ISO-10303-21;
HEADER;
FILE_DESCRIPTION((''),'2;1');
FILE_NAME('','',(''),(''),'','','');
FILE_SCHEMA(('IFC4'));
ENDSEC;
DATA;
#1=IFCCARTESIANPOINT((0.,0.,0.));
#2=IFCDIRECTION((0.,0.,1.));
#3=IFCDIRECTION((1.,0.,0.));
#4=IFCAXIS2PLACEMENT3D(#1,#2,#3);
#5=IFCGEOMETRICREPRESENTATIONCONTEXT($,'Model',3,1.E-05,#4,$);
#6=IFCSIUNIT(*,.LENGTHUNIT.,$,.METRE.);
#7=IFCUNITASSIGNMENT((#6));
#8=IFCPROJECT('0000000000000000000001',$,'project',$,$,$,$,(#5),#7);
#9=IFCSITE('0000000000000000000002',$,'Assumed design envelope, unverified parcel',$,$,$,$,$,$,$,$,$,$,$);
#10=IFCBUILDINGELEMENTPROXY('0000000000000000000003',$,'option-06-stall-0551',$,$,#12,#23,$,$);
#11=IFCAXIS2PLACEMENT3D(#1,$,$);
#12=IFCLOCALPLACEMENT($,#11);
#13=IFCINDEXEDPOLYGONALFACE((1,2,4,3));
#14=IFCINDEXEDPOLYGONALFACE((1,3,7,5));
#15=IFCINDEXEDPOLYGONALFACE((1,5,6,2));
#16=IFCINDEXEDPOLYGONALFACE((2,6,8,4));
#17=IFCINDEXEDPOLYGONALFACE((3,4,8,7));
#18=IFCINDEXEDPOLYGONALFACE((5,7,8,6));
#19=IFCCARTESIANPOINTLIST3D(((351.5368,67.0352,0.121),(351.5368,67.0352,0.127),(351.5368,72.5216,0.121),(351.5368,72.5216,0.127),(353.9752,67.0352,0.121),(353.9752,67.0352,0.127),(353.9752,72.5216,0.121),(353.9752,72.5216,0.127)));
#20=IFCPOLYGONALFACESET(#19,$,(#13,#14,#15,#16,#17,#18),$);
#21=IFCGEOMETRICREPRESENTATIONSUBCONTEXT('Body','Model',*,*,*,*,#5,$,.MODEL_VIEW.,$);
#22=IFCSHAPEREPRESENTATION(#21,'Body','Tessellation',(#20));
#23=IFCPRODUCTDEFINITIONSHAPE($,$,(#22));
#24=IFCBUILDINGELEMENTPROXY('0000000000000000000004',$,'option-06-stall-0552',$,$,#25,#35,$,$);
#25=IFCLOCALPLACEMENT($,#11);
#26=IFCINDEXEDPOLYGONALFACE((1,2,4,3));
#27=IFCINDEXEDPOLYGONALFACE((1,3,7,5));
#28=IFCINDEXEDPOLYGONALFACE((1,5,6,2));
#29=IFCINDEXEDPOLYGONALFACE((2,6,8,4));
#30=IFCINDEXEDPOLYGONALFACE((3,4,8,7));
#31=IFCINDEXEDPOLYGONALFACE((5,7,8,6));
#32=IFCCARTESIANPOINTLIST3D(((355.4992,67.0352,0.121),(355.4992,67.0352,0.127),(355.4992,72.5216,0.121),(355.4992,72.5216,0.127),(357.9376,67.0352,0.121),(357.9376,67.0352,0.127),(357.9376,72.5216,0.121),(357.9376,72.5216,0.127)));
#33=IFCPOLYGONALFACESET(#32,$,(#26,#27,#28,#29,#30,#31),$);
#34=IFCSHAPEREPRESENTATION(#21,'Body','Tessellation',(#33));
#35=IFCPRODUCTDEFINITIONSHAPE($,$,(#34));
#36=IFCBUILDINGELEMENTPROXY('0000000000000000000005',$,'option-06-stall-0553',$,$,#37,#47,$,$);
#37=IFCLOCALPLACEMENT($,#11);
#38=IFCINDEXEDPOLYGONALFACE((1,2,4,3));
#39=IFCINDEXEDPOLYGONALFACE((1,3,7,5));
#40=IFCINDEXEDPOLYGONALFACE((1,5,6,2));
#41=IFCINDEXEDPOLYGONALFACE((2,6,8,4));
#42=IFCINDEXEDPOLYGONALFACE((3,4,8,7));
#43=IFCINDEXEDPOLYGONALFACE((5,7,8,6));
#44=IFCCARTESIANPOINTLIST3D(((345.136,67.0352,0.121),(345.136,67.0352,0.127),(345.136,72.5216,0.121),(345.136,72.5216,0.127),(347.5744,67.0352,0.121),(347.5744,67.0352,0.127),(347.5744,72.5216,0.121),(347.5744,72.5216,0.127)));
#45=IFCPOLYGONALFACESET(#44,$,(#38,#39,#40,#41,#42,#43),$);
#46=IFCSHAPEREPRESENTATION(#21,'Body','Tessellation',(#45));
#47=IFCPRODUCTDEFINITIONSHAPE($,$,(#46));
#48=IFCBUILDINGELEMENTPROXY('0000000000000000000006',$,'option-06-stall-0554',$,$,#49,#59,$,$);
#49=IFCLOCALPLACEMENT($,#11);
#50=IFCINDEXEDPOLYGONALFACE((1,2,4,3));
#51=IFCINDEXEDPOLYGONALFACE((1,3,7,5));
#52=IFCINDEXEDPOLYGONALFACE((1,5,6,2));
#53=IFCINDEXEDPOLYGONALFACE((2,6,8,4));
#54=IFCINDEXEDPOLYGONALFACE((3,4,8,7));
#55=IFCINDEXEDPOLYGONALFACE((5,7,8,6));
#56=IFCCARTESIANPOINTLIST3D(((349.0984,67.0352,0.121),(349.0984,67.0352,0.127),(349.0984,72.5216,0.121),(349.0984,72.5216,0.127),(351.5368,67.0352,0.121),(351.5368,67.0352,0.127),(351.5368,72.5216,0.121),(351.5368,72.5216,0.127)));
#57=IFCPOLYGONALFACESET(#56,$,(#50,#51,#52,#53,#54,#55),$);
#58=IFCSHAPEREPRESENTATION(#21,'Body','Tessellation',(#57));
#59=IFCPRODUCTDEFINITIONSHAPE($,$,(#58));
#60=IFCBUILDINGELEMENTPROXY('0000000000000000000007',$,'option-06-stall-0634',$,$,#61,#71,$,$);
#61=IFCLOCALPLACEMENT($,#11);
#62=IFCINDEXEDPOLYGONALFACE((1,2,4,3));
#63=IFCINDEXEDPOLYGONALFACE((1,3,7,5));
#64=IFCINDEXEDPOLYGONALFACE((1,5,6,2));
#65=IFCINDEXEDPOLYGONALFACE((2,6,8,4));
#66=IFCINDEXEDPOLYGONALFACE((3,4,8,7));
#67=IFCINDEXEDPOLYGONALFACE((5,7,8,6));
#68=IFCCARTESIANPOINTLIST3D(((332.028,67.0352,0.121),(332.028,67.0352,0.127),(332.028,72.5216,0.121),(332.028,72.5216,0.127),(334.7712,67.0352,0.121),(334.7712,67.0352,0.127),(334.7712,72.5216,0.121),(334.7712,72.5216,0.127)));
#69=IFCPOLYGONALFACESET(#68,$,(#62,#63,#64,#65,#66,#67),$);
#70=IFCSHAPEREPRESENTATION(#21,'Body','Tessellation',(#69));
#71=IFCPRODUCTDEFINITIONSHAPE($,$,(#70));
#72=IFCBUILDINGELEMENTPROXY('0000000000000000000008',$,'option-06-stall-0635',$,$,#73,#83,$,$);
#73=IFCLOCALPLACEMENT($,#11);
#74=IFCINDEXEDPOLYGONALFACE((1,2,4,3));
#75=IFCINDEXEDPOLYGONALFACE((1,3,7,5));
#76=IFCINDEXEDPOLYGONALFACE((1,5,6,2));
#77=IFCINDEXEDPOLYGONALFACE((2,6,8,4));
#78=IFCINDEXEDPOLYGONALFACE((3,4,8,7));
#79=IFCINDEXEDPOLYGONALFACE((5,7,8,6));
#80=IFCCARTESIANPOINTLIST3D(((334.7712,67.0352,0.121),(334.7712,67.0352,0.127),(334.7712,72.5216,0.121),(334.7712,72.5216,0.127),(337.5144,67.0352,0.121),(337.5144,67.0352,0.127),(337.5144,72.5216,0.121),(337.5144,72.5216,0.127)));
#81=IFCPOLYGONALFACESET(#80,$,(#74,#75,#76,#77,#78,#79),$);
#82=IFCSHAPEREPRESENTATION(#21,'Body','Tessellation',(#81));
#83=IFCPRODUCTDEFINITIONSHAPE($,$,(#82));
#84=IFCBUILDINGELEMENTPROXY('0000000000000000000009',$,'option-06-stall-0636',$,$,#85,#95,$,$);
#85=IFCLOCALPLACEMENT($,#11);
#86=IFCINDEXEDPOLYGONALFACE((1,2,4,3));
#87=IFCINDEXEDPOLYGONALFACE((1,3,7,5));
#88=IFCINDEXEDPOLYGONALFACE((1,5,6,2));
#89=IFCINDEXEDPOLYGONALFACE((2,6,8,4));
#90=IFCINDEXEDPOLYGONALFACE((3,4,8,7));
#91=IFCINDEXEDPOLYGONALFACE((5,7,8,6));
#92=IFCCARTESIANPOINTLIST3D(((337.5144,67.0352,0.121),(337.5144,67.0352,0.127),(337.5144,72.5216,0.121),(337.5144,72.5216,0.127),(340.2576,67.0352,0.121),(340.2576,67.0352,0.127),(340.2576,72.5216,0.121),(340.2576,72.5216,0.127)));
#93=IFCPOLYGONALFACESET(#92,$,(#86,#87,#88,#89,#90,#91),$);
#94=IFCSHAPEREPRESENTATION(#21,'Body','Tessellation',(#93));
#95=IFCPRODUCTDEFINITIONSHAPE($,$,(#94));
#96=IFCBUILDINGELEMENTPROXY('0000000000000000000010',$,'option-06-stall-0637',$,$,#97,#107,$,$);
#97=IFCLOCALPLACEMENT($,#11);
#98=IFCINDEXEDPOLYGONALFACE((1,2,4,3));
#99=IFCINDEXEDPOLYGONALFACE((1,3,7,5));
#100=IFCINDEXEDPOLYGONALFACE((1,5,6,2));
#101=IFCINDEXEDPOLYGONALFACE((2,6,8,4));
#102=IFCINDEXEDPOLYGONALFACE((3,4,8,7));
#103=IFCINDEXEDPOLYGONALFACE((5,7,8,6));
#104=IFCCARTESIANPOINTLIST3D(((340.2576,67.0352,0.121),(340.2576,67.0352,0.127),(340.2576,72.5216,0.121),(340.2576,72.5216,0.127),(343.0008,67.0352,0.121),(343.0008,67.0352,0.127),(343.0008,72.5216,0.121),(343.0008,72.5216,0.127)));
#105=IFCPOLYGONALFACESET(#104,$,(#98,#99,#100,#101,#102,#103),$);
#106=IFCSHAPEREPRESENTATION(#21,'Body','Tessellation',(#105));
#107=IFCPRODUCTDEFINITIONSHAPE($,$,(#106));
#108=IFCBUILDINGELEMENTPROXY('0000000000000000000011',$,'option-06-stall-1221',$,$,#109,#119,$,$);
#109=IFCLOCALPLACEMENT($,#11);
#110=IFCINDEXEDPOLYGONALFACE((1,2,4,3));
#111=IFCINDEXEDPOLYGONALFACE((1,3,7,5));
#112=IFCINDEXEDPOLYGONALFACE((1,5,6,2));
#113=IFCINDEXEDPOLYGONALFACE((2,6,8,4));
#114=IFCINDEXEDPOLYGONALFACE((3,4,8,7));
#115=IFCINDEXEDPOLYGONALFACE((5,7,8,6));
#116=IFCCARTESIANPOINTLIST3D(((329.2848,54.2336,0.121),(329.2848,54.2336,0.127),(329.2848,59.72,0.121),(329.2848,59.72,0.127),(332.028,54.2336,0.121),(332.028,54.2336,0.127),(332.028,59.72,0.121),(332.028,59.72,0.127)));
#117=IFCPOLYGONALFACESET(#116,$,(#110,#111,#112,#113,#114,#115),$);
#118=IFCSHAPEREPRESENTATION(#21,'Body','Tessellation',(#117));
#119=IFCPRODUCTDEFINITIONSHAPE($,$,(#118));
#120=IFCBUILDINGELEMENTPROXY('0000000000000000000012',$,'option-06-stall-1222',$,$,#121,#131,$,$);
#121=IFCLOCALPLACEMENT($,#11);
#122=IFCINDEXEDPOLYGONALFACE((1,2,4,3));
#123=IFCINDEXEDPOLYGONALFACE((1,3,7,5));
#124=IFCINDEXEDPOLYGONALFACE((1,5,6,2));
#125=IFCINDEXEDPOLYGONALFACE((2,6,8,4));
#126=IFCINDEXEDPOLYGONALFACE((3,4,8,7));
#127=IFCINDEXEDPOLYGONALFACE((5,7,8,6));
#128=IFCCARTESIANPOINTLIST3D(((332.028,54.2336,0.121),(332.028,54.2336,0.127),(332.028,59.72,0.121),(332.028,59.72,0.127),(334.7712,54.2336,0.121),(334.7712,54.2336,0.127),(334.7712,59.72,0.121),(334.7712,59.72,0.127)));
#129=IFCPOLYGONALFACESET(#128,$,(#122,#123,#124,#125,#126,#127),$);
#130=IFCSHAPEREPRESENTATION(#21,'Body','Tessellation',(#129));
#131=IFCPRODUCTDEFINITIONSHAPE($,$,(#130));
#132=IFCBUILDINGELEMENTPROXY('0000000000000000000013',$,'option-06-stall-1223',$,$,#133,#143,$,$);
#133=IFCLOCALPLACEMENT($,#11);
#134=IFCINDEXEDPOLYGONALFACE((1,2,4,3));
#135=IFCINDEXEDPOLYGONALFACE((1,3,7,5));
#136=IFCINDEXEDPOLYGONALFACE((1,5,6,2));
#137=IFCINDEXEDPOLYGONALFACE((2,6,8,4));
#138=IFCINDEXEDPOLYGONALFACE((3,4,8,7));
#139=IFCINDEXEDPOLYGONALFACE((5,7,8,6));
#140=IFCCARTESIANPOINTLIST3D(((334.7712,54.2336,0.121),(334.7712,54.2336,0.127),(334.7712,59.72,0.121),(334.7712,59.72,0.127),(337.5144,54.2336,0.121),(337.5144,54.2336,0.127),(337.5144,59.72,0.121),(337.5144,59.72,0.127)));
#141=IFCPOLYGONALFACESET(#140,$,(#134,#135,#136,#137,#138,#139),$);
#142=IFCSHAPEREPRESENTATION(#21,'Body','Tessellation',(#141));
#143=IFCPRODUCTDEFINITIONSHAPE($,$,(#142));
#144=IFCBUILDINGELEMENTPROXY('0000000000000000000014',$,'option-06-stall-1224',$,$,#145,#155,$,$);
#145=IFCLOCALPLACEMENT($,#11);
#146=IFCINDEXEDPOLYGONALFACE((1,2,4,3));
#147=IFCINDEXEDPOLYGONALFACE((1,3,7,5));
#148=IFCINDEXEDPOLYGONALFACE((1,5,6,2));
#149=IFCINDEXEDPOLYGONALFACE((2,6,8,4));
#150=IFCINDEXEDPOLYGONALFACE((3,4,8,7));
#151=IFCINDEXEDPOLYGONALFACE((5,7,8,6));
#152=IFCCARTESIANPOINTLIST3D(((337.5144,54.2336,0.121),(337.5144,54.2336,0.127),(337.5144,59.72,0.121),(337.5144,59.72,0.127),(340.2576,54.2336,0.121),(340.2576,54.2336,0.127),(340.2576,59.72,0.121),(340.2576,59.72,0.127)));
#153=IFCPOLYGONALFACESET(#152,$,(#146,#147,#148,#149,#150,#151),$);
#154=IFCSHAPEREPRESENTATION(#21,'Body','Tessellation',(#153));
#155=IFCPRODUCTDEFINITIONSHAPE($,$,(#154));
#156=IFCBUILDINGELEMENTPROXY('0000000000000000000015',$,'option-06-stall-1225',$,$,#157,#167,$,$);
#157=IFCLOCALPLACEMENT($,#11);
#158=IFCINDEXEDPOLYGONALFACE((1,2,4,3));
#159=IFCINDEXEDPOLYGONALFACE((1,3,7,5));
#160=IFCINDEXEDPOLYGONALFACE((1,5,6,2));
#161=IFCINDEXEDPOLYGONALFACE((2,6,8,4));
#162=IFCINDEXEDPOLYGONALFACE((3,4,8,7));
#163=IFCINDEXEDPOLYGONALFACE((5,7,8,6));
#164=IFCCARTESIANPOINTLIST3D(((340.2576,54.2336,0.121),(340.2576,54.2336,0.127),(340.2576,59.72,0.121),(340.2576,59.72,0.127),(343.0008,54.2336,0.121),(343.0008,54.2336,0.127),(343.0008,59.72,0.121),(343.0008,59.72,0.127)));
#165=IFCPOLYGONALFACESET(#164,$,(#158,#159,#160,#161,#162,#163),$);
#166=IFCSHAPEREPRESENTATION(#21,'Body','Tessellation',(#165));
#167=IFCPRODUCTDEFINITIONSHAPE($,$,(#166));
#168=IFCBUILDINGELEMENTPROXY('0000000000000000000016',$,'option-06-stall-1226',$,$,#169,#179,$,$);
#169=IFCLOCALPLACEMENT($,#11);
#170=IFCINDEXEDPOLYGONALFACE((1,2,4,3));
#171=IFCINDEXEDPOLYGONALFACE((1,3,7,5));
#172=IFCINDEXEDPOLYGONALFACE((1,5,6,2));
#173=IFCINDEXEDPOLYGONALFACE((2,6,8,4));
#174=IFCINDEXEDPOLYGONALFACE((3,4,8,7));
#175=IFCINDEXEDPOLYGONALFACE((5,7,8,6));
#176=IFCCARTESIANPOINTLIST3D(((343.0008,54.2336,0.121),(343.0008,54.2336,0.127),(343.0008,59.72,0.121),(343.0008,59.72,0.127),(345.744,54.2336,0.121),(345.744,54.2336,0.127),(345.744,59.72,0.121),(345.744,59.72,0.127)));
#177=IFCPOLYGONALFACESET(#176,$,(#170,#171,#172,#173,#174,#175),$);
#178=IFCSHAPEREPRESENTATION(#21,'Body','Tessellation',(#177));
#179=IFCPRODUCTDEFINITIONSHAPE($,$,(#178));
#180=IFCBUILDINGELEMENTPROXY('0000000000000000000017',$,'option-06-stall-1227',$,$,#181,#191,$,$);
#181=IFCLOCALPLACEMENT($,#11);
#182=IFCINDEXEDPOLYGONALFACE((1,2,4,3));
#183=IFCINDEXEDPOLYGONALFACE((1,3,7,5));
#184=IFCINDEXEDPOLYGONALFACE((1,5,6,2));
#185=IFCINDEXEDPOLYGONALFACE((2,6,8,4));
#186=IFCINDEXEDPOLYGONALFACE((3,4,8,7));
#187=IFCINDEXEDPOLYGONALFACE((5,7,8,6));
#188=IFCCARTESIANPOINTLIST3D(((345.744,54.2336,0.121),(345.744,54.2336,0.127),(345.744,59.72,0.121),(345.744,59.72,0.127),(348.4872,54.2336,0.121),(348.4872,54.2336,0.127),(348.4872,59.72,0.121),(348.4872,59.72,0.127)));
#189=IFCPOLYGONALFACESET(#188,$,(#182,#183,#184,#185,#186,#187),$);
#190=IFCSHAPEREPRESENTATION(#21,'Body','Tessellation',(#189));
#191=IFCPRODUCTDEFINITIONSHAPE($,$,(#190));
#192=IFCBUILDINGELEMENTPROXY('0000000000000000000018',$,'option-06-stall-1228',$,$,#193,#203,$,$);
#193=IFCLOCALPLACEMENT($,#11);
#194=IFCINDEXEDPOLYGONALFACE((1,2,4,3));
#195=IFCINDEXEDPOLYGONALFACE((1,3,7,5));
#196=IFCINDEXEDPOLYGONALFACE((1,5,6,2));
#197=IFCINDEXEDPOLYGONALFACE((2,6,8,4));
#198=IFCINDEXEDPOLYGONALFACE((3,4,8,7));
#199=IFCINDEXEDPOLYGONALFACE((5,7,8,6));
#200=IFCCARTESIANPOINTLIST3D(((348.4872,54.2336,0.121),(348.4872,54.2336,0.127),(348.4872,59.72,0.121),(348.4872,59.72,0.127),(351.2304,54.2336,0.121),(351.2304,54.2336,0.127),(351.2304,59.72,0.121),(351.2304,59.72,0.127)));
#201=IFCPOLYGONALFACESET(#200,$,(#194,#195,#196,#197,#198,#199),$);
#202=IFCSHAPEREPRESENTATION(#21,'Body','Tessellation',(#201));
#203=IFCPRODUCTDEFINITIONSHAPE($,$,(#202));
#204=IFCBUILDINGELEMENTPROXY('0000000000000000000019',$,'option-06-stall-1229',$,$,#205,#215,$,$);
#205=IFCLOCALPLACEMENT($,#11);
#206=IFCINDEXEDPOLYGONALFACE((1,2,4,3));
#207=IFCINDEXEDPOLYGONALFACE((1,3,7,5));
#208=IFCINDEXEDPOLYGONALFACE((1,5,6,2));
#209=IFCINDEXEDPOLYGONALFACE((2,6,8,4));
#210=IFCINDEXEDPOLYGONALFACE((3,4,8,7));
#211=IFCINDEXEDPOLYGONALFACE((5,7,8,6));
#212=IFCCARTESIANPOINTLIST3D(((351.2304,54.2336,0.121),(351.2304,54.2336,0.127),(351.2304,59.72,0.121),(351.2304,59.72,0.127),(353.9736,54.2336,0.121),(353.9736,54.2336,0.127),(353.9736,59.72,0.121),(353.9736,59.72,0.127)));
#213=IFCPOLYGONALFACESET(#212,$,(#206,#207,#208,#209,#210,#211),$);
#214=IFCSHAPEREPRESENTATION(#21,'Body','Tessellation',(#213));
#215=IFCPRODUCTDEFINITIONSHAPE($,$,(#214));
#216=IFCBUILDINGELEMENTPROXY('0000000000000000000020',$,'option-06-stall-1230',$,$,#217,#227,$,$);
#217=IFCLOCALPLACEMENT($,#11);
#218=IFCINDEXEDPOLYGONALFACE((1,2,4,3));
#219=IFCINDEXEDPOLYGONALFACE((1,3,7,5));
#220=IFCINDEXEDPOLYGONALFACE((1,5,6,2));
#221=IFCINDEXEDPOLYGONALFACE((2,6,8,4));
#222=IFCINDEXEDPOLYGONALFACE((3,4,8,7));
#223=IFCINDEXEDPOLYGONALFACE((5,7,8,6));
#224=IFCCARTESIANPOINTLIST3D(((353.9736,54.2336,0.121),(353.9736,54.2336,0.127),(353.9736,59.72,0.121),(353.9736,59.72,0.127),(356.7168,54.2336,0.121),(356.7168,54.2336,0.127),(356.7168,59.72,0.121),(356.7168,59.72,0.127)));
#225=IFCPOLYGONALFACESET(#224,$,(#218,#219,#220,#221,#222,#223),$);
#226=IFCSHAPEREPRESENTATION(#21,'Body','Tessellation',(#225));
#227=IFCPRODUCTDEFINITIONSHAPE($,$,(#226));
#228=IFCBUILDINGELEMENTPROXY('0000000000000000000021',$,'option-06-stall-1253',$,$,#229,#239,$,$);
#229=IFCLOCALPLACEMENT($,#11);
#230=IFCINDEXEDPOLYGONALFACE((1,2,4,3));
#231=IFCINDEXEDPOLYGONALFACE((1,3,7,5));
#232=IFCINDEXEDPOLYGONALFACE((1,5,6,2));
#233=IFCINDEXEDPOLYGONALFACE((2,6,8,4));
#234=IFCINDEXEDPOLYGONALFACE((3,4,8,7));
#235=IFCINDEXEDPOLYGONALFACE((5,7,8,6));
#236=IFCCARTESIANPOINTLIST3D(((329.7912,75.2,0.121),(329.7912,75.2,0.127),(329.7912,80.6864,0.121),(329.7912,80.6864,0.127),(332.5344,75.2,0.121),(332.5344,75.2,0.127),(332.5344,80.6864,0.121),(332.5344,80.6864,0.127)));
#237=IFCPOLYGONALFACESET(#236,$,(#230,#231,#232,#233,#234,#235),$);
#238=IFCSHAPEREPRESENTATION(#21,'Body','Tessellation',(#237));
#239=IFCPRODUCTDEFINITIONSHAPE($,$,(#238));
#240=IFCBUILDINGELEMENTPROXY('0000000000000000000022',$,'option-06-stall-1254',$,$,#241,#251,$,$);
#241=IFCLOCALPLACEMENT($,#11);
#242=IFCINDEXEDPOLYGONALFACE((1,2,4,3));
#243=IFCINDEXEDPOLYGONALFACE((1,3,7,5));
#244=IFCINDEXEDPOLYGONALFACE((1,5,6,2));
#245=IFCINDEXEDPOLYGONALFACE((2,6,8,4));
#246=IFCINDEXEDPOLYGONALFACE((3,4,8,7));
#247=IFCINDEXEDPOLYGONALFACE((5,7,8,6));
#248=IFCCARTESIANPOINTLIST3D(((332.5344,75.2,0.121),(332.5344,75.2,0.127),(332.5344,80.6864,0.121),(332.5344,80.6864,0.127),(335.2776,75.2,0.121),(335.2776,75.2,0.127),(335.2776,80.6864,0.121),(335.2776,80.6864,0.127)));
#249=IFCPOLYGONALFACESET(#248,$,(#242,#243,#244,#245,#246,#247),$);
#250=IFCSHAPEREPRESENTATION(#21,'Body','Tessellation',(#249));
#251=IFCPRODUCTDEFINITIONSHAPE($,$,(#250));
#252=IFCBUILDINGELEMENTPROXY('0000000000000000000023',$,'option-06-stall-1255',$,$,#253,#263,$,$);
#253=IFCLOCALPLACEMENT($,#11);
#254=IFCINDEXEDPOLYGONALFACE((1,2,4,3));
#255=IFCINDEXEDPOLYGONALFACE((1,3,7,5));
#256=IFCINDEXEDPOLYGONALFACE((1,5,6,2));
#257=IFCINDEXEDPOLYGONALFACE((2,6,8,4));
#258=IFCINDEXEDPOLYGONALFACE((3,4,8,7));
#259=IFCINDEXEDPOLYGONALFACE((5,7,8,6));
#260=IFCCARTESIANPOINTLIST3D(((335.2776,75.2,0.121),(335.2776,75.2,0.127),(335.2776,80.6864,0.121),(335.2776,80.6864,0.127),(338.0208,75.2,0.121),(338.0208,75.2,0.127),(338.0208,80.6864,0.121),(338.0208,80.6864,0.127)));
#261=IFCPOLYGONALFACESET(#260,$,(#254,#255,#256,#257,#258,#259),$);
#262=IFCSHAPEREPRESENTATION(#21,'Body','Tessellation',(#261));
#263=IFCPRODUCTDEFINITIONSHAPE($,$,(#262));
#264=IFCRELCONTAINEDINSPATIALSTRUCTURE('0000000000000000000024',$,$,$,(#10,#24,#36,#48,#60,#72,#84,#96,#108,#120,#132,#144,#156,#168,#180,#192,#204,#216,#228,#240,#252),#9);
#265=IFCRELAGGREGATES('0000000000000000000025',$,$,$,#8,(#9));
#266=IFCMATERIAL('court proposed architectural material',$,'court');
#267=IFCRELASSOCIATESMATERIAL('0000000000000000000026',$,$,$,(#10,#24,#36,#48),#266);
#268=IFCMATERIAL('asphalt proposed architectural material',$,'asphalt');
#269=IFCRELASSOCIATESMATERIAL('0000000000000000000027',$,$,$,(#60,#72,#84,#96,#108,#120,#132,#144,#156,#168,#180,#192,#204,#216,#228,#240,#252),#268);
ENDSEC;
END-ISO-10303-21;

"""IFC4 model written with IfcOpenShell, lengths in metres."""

from ifc_helpers import new_model, si_unit, frame, origin_with_axes, place, context, subcontext, project, spatial, rectangle, extrude, material, element, save


model = new_model("IFC4")

# Units and contexts
model_context = context("Model", 3, precision=1e-05, world=origin_with_axes())
body_context = subcontext(model_context, "Body", "Model", "MODEL_VIEW")
ifc_project = project(units=[si_unit("LENGTHUNIT", "METRE")], contexts=[model_context])

# Site
site = spatial("IfcSite", under=ifc_project, Name="Assumed design envelope, unverified parcel")

# Building element proxies
ifc_material_1 = material(Name="court proposed architectural material", Category="court")
for number, where, z_axis, x_axis, name in (
    (1, (352.756, 69.7784, 0.121), (0.0, 0.0, 1.0), (1.0, 0.0, 0.0), "option-06-stall-0551"),
    (2, (356.7184, 69.7784, 0.121), (0.0, 0.0, 1.0), (1.0, 0.0, 0.0), "option-06-stall-0552"),
    (3, (346.3552, 69.7784, 0.121), (0.0, 0.0, 1.0), (1.0, 0.0, 0.0), "option-06-stall-0553"),
    (4, (350.3176, 69.7784, 0.121), (0.0, 0.0, 1.0), (1.0, 0.0, 0.0), "option-06-stall-0554"),
):
    element("IfcBuildingElementProxy", number, at=place(None, frame(where, z_axis=z_axis, x_axis=x_axis)), inside=site, material=ifc_material_1, Name=name, context=body_context, shape_type="SweptSolid", body=[
        extrude(rectangle(XDim=2.4384, YDim=5.4864), origin_with_axes(), (0.0, 0.0, 1.0), 0.006),
    ])
ifc_material_2 = material(Name="asphalt proposed architectural material", Category="asphalt")
for number, where, z_axis, x_axis, name in (
    (5, (333.3996, 69.7784, 0.121), (0.0, 0.0, 1.0), (1.0, 0.0, 0.0), "option-06-stall-0634"),
    (6, (336.1428, 69.7784, 0.121), (0.0, 0.0, 1.0), (1.0, 0.0, 0.0), "option-06-stall-0635"),
    (7, (338.886, 69.7784, 0.121), (0.0, 0.0, 1.0), (1.0, 0.0, 0.0), "option-06-stall-0636"),
    (8, (341.6292, 69.7784, 0.121), (0.0, 0.0, 1.0), (1.0, 0.0, 0.0), "option-06-stall-0637"),
    (9, (330.6564, 56.9768, 0.121), (0.0, 0.0, 1.0), (1.0, 0.0, 0.0), "option-06-stall-1221"),
    (10, (333.3996, 56.9768, 0.121), (0.0, 0.0, 1.0), (1.0, 0.0, 0.0), "option-06-stall-1222"),
    (11, (336.1428, 56.9768, 0.121), (0.0, 0.0, 1.0), (1.0, 0.0, 0.0), "option-06-stall-1223"),
    (12, (338.886, 56.9768, 0.121), (0.0, 0.0, 1.0), (1.0, 0.0, 0.0), "option-06-stall-1224"),
    (13, (341.6292, 56.9768, 0.121), (0.0, 0.0, 1.0), (1.0, 0.0, 0.0), "option-06-stall-1225"),
    (14, (344.3724, 56.9768, 0.121), (0.0, 0.0, 1.0), (1.0, 0.0, 0.0), "option-06-stall-1226"),
    (15, (347.1156, 56.9768, 0.121), (0.0, 0.0, 1.0), (1.0, 0.0, 0.0), "option-06-stall-1227"),
    (16, (349.8588, 56.9768, 0.121), (0.0, 0.0, 1.0), (1.0, 0.0, 0.0), "option-06-stall-1228"),
    (17, (352.602, 56.9768, 0.121), (0.0, 0.0, 1.0), (1.0, 0.0, 0.0), "option-06-stall-1229"),
    (18, (355.3452, 56.9768, 0.121), (0.0, 0.0, 1.0), (1.0, 0.0, 0.0), "option-06-stall-1230"),
    (19, (331.1628, 77.9432, 0.121), (0.0, 0.0, 1.0), (1.0, 0.0, 0.0), "option-06-stall-1253"),
    (20, (333.906, 77.9432, 0.121), (0.0, 0.0, 1.0), (1.0, 0.0, 0.0), "option-06-stall-1254"),
    (21, (336.6492, 77.9432, 0.121), (0.0, 0.0, 1.0), (1.0, 0.0, 0.0), "option-06-stall-1255"),
):
    element("IfcBuildingElementProxy", number, at=place(None, frame(where, z_axis=z_axis, x_axis=x_axis)), inside=site, material=ifc_material_2, Name=name, context=body_context, shape_type="SweptSolid", body=[
        extrude(rectangle(XDim=2.7432, YDim=5.4864), origin_with_axes(), (0.0, 0.0, 1.0), 0.006),
    ])

save(model, "model.ifc")
